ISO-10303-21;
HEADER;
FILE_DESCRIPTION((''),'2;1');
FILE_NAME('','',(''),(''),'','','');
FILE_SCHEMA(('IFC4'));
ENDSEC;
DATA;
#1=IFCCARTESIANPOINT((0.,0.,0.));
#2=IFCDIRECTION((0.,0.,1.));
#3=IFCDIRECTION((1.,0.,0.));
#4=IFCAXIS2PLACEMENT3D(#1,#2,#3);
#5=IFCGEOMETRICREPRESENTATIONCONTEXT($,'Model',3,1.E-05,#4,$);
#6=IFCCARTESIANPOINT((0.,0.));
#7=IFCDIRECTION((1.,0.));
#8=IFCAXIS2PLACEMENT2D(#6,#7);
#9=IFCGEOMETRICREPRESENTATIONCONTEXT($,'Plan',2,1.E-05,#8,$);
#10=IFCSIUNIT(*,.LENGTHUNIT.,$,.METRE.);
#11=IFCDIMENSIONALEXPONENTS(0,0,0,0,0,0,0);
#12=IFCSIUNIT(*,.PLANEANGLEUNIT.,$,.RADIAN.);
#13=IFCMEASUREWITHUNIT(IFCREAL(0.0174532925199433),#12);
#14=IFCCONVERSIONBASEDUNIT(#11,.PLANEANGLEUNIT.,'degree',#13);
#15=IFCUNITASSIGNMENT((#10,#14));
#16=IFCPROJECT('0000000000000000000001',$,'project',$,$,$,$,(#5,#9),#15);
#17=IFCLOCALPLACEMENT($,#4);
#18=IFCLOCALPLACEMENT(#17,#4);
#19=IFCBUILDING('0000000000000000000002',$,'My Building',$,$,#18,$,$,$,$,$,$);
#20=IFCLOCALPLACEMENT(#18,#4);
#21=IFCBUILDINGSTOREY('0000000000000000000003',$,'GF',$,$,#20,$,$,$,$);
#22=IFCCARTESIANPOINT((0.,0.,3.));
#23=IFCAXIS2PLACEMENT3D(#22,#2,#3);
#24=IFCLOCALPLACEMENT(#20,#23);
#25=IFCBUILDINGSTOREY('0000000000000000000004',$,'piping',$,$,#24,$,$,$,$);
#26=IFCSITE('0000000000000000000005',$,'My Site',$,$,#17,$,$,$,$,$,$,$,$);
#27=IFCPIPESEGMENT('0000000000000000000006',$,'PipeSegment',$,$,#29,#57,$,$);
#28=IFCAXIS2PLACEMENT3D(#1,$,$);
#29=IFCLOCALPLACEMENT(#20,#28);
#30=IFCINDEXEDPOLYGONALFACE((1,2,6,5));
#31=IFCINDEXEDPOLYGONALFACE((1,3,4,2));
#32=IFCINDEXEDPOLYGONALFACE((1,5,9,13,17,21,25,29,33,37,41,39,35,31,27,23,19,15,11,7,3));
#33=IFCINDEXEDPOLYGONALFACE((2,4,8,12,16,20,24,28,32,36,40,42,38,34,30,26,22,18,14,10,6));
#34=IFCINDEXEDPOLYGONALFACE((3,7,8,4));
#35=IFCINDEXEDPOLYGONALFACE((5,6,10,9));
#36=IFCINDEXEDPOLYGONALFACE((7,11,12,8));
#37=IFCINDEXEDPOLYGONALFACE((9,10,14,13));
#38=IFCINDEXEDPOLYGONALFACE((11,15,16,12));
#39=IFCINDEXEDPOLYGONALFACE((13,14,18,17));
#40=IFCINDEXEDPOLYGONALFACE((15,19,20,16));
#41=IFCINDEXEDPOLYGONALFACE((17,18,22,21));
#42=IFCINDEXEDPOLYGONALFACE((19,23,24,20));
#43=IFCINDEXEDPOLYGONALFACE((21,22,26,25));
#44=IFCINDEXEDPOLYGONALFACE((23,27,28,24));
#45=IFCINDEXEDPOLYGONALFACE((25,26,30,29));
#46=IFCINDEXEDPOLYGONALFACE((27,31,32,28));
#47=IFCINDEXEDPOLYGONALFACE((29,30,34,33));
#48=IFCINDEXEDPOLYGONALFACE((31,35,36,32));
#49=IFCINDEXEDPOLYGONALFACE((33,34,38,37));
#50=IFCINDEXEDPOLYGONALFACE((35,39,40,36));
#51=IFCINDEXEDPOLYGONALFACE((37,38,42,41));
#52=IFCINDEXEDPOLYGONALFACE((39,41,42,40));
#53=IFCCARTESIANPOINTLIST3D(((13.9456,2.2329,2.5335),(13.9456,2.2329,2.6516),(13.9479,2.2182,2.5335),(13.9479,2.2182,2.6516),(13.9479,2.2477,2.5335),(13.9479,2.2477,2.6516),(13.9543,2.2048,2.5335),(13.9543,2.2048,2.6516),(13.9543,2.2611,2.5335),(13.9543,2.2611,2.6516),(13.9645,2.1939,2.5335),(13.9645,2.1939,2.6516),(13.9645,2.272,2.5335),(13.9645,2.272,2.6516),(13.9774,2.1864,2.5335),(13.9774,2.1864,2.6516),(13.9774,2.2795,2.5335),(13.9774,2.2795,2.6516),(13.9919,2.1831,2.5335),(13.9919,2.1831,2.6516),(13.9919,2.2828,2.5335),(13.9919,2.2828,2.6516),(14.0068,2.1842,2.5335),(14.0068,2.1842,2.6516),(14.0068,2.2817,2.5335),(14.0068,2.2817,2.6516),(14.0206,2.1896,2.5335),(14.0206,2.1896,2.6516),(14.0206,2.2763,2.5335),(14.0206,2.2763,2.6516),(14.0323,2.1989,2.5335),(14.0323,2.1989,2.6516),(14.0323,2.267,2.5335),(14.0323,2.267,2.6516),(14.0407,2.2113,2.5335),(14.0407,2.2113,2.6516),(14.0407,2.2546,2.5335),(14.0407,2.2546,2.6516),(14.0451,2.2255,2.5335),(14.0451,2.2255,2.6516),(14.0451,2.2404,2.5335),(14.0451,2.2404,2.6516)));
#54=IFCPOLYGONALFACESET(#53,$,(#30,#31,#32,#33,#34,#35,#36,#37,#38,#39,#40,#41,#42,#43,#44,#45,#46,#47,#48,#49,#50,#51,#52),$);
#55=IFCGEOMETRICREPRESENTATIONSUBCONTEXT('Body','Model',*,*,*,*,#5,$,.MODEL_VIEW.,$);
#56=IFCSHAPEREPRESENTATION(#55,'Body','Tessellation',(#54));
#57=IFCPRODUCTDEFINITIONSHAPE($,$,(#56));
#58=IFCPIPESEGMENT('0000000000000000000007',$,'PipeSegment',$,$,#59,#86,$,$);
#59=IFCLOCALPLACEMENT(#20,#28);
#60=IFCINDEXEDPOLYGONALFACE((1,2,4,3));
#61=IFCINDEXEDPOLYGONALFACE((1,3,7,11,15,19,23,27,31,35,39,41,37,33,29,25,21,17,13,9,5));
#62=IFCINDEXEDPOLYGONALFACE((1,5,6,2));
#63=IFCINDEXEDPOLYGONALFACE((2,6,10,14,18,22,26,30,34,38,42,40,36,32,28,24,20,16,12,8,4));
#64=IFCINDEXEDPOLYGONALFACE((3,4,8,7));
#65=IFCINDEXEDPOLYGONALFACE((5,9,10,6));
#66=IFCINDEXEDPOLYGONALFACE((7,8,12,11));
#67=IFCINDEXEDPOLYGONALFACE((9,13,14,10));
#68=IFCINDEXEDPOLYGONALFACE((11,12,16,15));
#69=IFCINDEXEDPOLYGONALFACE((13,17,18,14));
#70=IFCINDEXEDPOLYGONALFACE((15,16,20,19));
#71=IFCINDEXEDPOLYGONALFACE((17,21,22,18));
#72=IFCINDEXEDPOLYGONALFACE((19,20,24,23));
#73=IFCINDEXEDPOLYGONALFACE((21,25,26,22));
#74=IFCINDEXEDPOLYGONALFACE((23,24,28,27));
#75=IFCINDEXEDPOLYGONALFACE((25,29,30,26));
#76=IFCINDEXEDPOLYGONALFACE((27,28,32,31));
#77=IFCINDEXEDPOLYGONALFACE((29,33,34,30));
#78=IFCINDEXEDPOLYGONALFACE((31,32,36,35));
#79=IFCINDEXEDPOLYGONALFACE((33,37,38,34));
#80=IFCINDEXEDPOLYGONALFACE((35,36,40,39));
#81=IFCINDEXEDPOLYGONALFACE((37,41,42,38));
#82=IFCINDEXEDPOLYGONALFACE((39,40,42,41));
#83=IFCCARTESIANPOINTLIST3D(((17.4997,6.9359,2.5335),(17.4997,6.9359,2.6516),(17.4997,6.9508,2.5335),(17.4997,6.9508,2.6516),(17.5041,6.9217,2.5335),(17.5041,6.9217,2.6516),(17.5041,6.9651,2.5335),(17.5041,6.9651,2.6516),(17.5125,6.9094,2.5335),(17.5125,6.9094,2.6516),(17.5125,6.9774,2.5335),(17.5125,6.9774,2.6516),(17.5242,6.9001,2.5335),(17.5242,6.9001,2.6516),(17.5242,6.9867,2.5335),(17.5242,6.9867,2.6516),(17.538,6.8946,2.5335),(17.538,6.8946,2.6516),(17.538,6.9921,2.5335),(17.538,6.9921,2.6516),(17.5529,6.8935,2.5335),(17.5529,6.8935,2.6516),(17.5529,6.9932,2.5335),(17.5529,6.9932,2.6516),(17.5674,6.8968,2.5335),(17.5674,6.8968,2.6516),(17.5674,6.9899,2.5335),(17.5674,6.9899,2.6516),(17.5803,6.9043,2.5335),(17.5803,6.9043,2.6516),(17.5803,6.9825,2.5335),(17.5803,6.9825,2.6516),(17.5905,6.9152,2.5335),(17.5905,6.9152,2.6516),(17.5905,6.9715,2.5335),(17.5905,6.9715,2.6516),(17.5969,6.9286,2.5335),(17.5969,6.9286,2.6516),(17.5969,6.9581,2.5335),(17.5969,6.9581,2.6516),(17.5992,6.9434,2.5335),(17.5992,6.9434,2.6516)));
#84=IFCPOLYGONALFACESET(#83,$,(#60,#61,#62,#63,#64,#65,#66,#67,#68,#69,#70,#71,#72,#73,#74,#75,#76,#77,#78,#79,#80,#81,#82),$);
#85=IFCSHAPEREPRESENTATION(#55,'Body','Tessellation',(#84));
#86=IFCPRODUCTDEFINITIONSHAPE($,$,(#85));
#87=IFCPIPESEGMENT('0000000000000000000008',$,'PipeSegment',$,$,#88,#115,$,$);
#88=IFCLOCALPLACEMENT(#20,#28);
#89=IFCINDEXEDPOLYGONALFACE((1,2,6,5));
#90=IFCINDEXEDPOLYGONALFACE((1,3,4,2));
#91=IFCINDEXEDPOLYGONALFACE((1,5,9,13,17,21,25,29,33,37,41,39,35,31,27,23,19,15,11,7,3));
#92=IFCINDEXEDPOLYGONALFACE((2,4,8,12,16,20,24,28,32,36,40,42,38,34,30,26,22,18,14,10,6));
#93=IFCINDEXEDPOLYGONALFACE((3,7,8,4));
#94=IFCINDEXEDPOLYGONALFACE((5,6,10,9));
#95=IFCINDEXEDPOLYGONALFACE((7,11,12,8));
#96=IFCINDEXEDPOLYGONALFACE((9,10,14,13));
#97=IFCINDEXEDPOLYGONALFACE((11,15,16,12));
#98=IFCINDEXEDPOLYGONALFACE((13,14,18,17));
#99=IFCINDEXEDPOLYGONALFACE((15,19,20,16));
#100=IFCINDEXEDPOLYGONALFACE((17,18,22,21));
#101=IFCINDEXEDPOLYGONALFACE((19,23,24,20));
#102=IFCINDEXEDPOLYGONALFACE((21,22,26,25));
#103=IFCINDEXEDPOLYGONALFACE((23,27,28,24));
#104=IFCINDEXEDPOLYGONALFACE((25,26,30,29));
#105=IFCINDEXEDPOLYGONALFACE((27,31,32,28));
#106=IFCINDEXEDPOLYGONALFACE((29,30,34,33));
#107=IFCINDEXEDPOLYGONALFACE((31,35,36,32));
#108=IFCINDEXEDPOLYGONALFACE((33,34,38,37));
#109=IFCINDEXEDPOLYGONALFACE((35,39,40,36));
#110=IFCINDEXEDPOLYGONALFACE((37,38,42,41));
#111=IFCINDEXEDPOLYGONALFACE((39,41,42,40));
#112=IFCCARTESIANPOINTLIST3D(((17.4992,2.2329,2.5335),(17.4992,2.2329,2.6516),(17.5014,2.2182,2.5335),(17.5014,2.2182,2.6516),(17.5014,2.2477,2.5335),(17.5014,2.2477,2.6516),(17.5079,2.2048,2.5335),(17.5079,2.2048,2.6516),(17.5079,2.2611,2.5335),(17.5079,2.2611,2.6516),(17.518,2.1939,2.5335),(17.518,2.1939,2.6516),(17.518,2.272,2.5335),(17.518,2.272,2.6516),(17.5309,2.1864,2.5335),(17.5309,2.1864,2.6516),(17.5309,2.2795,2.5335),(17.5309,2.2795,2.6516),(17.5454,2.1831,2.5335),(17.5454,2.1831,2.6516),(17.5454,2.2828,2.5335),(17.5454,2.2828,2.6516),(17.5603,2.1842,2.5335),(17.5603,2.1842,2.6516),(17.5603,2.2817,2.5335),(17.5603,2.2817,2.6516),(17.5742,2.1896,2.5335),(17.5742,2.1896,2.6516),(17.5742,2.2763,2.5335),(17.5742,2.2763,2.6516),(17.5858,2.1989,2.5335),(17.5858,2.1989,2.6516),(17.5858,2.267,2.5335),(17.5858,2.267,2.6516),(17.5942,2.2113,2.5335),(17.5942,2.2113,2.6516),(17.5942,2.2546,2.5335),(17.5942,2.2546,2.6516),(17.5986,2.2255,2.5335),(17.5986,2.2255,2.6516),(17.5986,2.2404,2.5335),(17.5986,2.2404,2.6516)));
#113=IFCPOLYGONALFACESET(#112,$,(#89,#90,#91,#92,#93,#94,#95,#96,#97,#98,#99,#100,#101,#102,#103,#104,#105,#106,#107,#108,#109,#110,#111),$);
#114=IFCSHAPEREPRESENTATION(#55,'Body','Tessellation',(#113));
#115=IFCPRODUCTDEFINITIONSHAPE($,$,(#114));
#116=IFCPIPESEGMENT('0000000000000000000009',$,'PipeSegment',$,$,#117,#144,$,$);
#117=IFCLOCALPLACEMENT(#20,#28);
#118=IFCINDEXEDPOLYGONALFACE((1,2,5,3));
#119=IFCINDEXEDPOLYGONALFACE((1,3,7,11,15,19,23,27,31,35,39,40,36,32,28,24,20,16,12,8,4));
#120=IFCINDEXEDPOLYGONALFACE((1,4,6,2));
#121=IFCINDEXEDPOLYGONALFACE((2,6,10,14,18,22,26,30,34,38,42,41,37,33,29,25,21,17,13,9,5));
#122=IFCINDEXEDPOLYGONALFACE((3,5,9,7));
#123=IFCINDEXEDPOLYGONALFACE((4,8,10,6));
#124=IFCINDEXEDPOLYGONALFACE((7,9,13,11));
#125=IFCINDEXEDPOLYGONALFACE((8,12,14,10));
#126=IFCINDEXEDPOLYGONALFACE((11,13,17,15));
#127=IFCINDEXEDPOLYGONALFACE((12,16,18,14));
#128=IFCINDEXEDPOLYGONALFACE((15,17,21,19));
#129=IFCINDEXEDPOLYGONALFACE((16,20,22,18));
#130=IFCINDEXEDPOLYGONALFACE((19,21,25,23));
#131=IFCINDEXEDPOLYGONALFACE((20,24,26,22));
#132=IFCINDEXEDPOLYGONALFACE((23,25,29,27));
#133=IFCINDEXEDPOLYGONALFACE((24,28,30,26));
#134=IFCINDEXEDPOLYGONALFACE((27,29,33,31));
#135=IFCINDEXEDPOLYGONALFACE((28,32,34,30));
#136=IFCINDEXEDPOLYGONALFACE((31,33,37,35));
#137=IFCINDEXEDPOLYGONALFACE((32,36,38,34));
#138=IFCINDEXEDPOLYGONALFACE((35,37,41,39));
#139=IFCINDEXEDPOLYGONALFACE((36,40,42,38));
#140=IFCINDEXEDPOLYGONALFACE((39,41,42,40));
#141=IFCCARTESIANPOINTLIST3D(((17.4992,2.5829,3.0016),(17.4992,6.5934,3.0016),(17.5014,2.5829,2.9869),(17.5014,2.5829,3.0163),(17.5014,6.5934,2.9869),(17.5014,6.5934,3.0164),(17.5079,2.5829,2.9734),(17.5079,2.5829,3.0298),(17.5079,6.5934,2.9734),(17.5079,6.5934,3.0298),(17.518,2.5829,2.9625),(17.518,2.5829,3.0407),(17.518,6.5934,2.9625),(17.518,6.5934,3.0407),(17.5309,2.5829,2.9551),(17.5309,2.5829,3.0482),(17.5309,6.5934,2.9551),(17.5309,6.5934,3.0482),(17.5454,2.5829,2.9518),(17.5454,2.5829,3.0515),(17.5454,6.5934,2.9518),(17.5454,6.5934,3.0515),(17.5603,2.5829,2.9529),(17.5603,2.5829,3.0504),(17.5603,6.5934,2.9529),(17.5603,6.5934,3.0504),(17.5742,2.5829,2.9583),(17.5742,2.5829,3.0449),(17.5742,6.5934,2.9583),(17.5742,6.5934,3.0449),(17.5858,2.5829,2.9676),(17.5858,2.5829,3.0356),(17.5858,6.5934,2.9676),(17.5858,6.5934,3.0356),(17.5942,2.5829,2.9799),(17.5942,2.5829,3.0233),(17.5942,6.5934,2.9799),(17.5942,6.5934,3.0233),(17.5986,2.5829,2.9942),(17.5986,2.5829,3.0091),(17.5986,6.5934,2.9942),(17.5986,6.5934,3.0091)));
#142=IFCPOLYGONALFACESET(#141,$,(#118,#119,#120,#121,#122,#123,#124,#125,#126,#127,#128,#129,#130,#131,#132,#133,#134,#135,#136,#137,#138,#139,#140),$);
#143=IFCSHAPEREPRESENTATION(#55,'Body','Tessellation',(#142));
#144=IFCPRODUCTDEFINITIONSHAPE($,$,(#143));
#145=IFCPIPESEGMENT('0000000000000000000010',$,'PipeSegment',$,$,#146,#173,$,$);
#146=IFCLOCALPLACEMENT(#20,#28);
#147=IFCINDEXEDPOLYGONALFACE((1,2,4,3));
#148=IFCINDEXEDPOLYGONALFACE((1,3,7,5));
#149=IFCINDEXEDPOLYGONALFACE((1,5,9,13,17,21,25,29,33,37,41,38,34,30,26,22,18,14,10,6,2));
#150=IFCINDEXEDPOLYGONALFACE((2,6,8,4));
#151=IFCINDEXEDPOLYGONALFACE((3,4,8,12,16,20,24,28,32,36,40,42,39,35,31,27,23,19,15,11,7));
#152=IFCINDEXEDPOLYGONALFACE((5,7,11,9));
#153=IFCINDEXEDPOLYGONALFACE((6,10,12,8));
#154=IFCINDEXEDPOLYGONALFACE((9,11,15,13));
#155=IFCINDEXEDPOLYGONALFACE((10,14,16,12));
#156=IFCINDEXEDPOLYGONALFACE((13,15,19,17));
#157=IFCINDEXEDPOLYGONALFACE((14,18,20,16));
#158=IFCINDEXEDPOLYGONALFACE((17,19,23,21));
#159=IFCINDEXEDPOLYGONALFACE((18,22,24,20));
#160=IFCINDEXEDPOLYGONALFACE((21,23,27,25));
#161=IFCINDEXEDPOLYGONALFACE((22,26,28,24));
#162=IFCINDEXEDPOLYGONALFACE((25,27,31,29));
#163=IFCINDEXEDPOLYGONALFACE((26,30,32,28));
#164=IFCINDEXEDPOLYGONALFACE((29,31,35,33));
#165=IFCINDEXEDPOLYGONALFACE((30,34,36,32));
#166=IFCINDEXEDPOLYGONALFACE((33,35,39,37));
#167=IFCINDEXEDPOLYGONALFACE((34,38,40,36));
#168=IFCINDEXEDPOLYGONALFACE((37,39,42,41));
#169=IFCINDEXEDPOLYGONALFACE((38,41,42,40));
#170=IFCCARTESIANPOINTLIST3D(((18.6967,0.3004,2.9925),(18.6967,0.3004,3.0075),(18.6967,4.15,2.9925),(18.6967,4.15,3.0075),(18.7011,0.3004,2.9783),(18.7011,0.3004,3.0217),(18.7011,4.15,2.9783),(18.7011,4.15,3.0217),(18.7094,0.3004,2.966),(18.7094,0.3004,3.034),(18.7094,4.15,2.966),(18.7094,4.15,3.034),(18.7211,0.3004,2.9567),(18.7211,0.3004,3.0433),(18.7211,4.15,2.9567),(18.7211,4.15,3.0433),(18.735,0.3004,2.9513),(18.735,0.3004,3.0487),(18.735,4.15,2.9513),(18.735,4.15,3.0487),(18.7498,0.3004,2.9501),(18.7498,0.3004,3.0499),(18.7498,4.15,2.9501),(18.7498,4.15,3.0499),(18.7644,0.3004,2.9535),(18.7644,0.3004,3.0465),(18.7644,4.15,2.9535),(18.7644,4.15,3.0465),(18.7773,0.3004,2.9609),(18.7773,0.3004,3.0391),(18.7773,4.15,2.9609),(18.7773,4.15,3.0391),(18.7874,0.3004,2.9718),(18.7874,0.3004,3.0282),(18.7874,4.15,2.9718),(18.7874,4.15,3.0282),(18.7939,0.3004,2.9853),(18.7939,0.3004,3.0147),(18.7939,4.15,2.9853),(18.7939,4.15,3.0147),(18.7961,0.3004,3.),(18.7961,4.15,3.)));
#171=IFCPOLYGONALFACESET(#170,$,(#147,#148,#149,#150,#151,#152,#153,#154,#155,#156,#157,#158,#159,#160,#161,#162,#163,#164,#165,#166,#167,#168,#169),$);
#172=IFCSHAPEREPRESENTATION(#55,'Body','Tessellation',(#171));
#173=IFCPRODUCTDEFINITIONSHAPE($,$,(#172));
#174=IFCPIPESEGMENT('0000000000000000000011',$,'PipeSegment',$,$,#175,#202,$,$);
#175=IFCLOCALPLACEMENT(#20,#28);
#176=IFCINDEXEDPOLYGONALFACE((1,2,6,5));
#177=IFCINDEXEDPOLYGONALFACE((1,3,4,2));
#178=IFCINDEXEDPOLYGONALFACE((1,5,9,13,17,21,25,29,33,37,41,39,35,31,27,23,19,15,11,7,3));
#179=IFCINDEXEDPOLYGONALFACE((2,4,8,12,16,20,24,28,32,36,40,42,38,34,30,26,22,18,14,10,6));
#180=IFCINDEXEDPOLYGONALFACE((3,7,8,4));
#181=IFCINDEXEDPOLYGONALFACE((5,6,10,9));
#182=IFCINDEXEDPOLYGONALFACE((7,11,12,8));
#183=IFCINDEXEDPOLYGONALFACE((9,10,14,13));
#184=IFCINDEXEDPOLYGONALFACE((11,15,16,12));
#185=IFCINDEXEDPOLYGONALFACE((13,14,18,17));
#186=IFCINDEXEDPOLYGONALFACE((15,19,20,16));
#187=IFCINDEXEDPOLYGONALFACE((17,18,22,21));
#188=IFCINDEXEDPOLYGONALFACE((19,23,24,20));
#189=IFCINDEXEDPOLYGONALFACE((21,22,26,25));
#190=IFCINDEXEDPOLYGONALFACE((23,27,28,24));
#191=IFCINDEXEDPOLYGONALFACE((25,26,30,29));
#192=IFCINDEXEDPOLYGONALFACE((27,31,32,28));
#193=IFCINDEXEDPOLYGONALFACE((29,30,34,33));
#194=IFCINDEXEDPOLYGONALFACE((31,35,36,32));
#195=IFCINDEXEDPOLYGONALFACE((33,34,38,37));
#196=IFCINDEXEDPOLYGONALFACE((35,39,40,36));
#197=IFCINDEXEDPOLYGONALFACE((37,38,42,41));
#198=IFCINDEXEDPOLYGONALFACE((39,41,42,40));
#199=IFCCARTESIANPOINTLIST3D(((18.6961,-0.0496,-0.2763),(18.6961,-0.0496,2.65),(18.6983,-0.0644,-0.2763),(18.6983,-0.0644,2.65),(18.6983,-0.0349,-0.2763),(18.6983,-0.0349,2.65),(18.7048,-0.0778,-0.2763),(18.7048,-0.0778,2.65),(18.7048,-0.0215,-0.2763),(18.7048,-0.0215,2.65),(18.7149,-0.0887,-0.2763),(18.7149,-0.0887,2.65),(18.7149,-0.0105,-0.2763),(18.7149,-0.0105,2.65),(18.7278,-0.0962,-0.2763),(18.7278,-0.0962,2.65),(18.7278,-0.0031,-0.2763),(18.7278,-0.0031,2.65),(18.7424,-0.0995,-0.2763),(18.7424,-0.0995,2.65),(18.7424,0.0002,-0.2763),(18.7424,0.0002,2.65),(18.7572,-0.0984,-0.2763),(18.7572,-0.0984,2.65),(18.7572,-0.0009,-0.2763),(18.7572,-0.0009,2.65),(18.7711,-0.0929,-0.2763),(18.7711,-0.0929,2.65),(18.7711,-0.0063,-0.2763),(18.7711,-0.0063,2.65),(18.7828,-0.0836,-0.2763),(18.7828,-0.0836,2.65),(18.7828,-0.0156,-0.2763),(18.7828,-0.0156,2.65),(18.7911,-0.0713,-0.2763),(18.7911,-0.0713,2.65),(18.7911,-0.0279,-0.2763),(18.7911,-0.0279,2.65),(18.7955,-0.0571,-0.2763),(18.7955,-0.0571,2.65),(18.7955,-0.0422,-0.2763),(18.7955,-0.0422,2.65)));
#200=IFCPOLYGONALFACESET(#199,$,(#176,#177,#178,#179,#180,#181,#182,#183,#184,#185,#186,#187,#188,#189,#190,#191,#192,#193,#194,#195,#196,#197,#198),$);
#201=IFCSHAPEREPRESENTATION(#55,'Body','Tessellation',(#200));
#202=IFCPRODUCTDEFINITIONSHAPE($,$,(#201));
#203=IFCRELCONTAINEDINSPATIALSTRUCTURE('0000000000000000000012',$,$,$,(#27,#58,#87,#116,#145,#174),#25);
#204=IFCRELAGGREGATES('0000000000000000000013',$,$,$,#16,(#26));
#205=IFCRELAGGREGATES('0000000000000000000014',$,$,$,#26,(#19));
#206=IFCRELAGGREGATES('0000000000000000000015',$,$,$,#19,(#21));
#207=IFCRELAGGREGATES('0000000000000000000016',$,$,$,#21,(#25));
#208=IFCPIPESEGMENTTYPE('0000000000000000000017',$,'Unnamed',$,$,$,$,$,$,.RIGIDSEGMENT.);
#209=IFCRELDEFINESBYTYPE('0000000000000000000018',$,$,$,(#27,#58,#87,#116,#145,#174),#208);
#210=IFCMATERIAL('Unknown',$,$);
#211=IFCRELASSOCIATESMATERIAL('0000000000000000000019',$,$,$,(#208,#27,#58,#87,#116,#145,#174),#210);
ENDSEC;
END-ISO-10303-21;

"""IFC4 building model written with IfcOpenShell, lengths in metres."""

from ifc_helpers import new_model, entity, si_unit, converted_unit, frame, origin_with_axes, origin_2d_with_axis, place, context, subcontext, project, spatial, circle, extrude, material, material_profile, profile_set, profile_usage, type_object, element, save


model = new_model("IFC4")

# Units and contexts
model_context = context("Model", 3, precision=1e-05, world=origin_with_axes())
plan_context = context("Plan", 2, precision=1e-05, world=origin_2d_with_axis())
body_context = subcontext(model_context, "Body", "Model", "MODEL_VIEW")
ifc_project = project(units=[si_unit("LENGTHUNIT", "METRE"), converted_unit("PLANEANGLEUNIT", "degree", entity("IfcReal", 0.0174532925199433), si_unit("PLANEANGLEUNIT", "RADIAN"), dimensions=[0, 0, 0, 0, 0, 0, 0])], contexts=[model_context, plan_context])

# Site, building, storeys
site_placement = place(None, origin_with_axes())
site = spatial("IfcSite", under=ifc_project, at=site_placement, Name="My Site")
building_placement = place(site_placement, origin_with_axes())
building = spatial("IfcBuilding", under=site, at=building_placement, Name="My Building")
storey_1_placement = place(building_placement, origin_with_axes())
storey_1 = spatial("IfcBuildingStorey", under=building, at=storey_1_placement, Name="GF")
storey_2_placement = place(storey_1_placement, frame((0.0, 0.0, 3.0), z_axis=(0.0, 0.0, 1.0), x_axis=(1.0, 0.0, 0.0)))
storey_2 = spatial("IfcBuildingStorey", under=storey_1, at=storey_2_placement, Name="piping")

# Pipe segments
ifc_material = material(Name="Unknown")
ifc_material_profile = material_profile(ifc_material, circle(Radius=0.05))
ifc_profile_set = profile_set([ifc_material_profile])
pipe_segment_type = type_object("IfcPipeSegmentType", Name="Unnamed", PredefinedType="RIGIDSEGMENT", material=ifc_profile_set)
ifc_profile_usage_1 = profile_usage(ifc_profile_set, cardinal=5)
pipe_segment_1_placement = place(storey_2_placement, frame((13.9956, 2.2329, -0.3484), z_axis=(0.0, 0.0, -1.0), x_axis=(-1.0, 0.0, 0.0)))
element("IfcPipeSegment", 1, at=pipe_segment_1_placement, inside=storey_2, type_object=pipe_segment_type, material=ifc_profile_usage_1, Name="PipeSegment", context=body_context, shape_type="SweptSolid", body=[
    extrude(circle(Radius=0.05), origin_with_axes(), (0.0, 0.0, 1.0), 0.1181),
])
ifc_profile_usage_2 = profile_usage(ifc_profile_set, cardinal=5)
pipe_segment_2_placement = place(storey_2_placement, frame((17.5492, 6.9434, -0.3484), z_axis=(0.0, 0.0, -1.0), x_axis=(1.0, 0.0, 0.0)))
element("IfcPipeSegment", 2, at=pipe_segment_2_placement, inside=storey_2, type_object=pipe_segment_type, material=ifc_profile_usage_2, Name="PipeSegment", context=body_context, shape_type="SweptSolid", body=[
    extrude(circle(Radius=0.05), origin_with_axes(), (0.0, 0.0, 1.0), 0.1181),
])
ifc_profile_usage_3 = profile_usage(ifc_profile_set, cardinal=5)
pipe_segment_3_placement = place(storey_2_placement, frame((17.5492, 2.2329, -0.3484), z_axis=(0.0, 0.0, -1.0), x_axis=(-1.0, 0.0, 0.0)))
element("IfcPipeSegment", 3, at=pipe_segment_3_placement, inside=storey_2, type_object=pipe_segment_type, material=ifc_profile_usage_3, Name="PipeSegment", context=body_context, shape_type="SweptSolid", body=[
    extrude(circle(Radius=0.05), origin_with_axes(), (0.0, 0.0, 1.0), 0.1181),
])
ifc_profile_usage_4 = profile_usage(ifc_profile_set, cardinal=5)
pipe_segment_4_placement = place(storey_2_placement, frame((17.5492, 2.5829, 0.0016), z_axis=(0.0, 1.0, 0.0), x_axis=(-1.0, 0.0, 0.0)))
element("IfcPipeSegment", 4, at=pipe_segment_4_placement, inside=storey_2, type_object=pipe_segment_type, material=ifc_profile_usage_4, Name="PipeSegment", context=body_context, shape_type="SweptSolid", body=[
    extrude(circle(Radius=0.05), origin_with_axes(), (0.0, 0.0, 1.0), 4.0104),
])
ifc_profile_usage_5 = profile_usage(ifc_profile_set, cardinal=5)
pipe_segment_5_placement = place(storey_2_placement, frame((18.7461, 4.15, 0.0), z_axis=(0.0, -1.0, 0.0), x_axis=(1.0, 0.0, 0.0)))
element("IfcPipeSegment", 5, at=pipe_segment_5_placement, inside=storey_2, type_object=pipe_segment_type, material=ifc_profile_usage_5, Name="PipeSegment", context=body_context, shape_type="SweptSolid", body=[
    extrude(circle(Radius=0.05), origin_with_axes(), (0.0, 0.0, 1.0), 3.8496),
])
ifc_profile_usage_6 = profile_usage(ifc_profile_set, cardinal=5)
pipe_segment_6_placement = place(storey_2_placement, frame((18.7461, -0.0496, -0.35), z_axis=(0.0, 0.0, -1.0), x_axis=(-1.0, 0.0, 0.0)))
element("IfcPipeSegment", 6, at=pipe_segment_6_placement, inside=storey_2, type_object=pipe_segment_type, material=ifc_profile_usage_6, Name="PipeSegment", context=body_context, shape_type="SweptSolid", body=[
    extrude(circle(Radius=0.05), origin_with_axes(), (0.0, 0.0, 1.0), 2.9263),
])

save(model, "model.ifc")
